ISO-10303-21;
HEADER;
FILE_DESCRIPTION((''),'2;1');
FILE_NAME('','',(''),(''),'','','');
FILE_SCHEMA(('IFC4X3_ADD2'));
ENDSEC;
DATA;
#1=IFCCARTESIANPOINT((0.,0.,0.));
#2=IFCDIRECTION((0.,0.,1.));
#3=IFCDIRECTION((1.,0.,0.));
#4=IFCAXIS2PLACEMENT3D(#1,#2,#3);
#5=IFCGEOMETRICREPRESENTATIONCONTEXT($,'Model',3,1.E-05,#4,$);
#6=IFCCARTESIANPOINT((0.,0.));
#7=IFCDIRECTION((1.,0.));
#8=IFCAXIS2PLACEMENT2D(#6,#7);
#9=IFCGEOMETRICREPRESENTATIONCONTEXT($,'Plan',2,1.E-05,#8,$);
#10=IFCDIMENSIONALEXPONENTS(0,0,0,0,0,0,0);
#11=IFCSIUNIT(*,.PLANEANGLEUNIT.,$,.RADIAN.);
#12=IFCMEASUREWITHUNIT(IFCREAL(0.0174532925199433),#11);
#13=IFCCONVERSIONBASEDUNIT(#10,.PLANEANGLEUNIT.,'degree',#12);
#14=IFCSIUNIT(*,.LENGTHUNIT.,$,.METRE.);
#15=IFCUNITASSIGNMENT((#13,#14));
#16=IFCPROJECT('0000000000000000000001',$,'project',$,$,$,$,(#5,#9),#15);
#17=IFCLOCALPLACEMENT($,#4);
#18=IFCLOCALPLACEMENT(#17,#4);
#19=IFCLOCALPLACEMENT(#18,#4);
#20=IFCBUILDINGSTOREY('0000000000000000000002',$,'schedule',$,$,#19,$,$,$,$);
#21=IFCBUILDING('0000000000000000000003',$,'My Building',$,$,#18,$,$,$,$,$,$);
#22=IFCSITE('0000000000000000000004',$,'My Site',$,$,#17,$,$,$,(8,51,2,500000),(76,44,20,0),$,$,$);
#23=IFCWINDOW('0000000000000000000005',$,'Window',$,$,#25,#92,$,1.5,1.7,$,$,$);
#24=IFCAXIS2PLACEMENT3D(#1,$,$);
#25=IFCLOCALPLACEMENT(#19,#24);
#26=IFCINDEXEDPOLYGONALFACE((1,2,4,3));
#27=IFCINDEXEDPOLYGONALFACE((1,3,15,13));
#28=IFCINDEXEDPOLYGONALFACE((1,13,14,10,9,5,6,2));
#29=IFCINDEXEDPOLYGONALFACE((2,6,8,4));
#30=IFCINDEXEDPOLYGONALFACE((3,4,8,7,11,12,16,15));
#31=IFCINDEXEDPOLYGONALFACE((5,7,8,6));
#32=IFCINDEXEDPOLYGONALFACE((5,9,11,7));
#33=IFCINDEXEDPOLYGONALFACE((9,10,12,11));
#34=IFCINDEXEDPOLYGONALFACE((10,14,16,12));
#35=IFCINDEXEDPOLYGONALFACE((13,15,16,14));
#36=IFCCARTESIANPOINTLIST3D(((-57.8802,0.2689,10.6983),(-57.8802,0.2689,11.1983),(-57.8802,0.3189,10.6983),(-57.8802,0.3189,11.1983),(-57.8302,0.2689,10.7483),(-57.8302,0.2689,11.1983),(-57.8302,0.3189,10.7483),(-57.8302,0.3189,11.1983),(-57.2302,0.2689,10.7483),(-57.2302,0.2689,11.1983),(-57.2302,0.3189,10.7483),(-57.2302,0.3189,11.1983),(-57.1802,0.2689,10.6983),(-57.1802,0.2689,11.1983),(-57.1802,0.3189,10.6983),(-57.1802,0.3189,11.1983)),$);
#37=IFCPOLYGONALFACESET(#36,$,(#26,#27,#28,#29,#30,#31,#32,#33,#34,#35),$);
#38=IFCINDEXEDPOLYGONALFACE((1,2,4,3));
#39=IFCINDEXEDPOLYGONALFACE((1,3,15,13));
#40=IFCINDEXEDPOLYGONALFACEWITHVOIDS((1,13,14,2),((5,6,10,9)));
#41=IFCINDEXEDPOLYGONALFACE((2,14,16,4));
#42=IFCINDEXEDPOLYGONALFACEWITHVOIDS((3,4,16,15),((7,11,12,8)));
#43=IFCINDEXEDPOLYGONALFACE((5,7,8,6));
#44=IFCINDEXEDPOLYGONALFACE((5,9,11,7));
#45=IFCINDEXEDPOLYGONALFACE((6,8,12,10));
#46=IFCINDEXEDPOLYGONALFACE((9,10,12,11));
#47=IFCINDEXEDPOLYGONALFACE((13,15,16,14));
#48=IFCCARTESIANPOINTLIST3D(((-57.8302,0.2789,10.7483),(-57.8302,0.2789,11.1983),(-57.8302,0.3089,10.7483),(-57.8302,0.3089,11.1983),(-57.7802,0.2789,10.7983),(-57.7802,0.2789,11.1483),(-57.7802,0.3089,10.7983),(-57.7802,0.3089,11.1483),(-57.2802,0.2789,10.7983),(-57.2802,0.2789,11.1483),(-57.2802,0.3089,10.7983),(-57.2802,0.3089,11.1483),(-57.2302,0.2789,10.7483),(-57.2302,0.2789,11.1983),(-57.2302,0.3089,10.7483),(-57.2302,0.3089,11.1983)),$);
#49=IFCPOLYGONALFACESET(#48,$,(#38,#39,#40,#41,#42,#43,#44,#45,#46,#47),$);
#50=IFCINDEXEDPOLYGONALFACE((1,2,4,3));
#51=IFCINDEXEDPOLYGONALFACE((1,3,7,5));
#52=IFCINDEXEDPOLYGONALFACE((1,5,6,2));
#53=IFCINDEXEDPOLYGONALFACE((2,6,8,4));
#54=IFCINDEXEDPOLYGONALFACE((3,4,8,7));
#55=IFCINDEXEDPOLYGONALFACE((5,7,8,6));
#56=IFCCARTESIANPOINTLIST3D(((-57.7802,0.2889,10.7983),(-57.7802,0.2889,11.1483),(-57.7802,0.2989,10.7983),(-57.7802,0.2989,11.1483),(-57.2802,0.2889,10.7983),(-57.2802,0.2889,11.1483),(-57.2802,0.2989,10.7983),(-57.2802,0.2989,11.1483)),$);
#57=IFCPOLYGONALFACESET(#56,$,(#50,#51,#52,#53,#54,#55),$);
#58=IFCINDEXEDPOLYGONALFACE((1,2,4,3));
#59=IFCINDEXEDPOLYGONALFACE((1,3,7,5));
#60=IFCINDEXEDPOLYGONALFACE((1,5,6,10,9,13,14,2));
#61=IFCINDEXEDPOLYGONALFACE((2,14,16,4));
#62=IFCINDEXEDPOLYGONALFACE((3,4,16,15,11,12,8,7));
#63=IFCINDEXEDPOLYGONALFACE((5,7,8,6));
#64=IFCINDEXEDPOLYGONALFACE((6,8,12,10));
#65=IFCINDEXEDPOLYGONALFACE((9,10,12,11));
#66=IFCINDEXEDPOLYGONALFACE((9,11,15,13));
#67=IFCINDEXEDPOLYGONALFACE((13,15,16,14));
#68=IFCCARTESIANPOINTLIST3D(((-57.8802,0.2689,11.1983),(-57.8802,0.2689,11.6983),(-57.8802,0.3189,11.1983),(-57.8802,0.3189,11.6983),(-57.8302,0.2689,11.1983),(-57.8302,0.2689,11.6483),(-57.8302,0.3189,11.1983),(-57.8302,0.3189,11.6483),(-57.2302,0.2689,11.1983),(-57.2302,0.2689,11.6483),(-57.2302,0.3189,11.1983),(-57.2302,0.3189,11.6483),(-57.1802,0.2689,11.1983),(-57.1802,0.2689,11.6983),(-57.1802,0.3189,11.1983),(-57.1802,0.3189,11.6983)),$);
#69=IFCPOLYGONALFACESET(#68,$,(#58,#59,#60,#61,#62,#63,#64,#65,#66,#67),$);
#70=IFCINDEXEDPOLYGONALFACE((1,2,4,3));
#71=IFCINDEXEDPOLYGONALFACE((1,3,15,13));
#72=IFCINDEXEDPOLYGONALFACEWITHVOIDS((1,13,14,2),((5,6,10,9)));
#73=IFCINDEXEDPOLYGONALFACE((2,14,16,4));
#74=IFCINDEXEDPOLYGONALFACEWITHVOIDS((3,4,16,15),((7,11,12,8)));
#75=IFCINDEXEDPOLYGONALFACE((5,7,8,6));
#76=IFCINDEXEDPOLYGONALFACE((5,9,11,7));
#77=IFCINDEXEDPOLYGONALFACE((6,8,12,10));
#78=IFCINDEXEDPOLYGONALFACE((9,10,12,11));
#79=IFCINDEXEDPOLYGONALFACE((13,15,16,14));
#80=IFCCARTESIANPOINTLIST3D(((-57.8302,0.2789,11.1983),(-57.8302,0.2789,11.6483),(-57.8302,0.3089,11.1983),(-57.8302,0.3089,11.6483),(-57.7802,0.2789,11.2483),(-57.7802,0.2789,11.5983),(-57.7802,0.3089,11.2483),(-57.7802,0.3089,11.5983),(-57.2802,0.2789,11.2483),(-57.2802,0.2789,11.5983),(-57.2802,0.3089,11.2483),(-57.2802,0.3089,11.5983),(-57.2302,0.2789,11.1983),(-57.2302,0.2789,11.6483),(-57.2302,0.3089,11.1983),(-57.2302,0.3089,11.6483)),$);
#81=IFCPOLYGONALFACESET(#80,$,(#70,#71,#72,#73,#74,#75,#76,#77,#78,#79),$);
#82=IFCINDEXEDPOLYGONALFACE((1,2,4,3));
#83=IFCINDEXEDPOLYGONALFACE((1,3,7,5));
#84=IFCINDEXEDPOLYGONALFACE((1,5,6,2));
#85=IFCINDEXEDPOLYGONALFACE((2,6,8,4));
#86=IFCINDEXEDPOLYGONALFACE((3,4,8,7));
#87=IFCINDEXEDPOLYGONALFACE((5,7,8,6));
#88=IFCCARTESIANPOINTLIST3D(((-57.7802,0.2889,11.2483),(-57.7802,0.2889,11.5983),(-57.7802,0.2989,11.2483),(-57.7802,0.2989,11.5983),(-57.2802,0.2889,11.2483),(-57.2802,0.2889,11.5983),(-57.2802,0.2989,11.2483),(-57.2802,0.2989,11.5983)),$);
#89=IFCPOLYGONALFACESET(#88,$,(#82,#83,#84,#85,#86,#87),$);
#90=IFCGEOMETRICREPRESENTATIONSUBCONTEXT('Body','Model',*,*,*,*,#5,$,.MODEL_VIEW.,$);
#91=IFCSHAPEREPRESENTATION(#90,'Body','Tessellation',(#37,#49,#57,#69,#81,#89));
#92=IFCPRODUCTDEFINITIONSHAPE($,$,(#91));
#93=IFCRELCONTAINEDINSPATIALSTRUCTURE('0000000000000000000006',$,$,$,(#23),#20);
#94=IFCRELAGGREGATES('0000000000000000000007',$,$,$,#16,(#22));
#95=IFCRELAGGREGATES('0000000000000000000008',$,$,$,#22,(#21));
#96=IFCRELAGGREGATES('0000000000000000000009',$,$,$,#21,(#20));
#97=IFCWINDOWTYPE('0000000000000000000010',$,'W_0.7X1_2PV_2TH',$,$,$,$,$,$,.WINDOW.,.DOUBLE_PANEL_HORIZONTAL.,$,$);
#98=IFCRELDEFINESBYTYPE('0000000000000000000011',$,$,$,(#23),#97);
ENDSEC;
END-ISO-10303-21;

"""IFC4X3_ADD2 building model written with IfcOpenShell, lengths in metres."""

from ifc_helpers import new_model, entity, si_unit, converted_unit, frame, origin_with_axes, origin_2d_with_axis, place, context, subcontext, project, spatial, line, indexed_curve, outline, extrude, shape, source, transform, mapped, type_object, type_shapes, element, save


model = new_model("IFC4X3_ADD2")

# Units and contexts
model_context = context("Model", 3, precision=1e-05, world=origin_with_axes())
plan_context = context("Plan", 2, precision=1e-05, world=origin_2d_with_axis())
body_context_1 = subcontext(model_context, "Body", "Model", "MODEL_VIEW")
body_context_2 = subcontext(plan_context, "Body", "Plan", "PLAN_VIEW")
ifc_project = project(units=[converted_unit("PLANEANGLEUNIT", "degree", entity("IfcReal", 0.0174532925199433), si_unit("PLANEANGLEUNIT", "RADIAN"), dimensions=[0, 0, 0, 0, 0, 0, 0]), si_unit("LENGTHUNIT", "METRE")], contexts=[model_context, plan_context])

# Site, building, storey
site_placement = place(None, origin_with_axes())
site = spatial("IfcSite", under=ifc_project, at=site_placement, Name="My Site", RefLatitude=(8, 51, 2, 500000), RefLongitude=(76, 44, 20, 0))
building_placement = place(site_placement, origin_with_axes())
building = spatial("IfcBuilding", under=site, at=building_placement, Name="My Building")
storey_placement = place(building_placement, origin_with_axes())
storey = spatial("IfcBuildingStorey", under=building, at=storey_placement, Name="schedule")

# Window
placement_1 = place(storey_placement, frame((-67.8485, 0.2689, 3.1152), z_axis=(0.0, 0.0, 1.0), x_axis=(1.0, 0.0, 0.0)))
window_type_1 = type_object("IfcWindowType", Name="W_0.7X1_2PV_2TH", PartitioningType="DOUBLE_PANEL_HORIZONTAL", PredefinedType="WINDOW")
shared_shape_1 = source(origin_with_axes(), body_context_1, "Body", "SweptSolid", [
    extrude(outline(indexed_curve([(0.7, 0.5), (0.7, 0.0), (0.0, 0.0), (0.0, 0.5), (0.05, 0.5), (0.05, 0.05), (0.65, 0.05), (0.65, 0.5)], segments=[line(1, 2, 3, 4, 5, 6, 7, 8, 1)])), frame((0.0, 0.0, 0.0), z_axis=(0.0, -1.0, 0.0), x_axis=(1.0, 0.0, 0.0)), (0.0, 0.0, -1.0), 0.05),
    extrude(outline(indexed_curve([(0.0, 0.0), (0.6, 0.0), (0.6, 0.45), (0.0, 0.45)], segments=[line(1, 2, 3, 4, 1)]), holes=[indexed_curve([(0.05, 0.05), (0.55, 0.05), (0.55, 0.4), (0.05, 0.4)], segments=[line(1, 2, 3, 4, 1)])]), frame((0.05, 0.01, 0.05), z_axis=(0.0, -1.0, 0.0), x_axis=(1.0, 0.0, 0.0)), (0.0, 0.0, -1.0), 0.03),
    extrude(outline(indexed_curve([(0.05, 0.05), (0.55, 0.05), (0.55, 0.4), (0.05, 0.4)], segments=[line(1, 2, 3, 4, 1)])), frame((0.05, 0.02, 0.05), z_axis=(0.0, -1.0, 0.0), x_axis=(1.0, 0.0, 0.0)), (0.0, 0.0, -1.0), 0.01),
    extrude(outline(indexed_curve([(0.0, 0.0), (0.0, 0.5), (0.7, 0.5), (0.7, 0.0), (0.65, 0.0), (0.65, 0.45), (0.05, 0.45), (0.05, 0.0)], segments=[line(1, 2, 3, 4, 5, 6, 7, 8, 1)])), frame((0.0, 0.0, 0.5), z_axis=(0.0, -1.0, 0.0), x_axis=(1.0, 0.0, 0.0)), (0.0, 0.0, -1.0), 0.05),
    extrude(outline(indexed_curve([(0.0, 0.0), (0.6, 0.0), (0.6, 0.45), (0.0, 0.45)], segments=[line(1, 2, 3, 4, 1)]), holes=[indexed_curve([(0.05, 0.05), (0.55, 0.05), (0.55, 0.4), (0.05, 0.4)], segments=[line(1, 2, 3, 4, 1)])]), frame((0.05, 0.01, 0.5), z_axis=(0.0, -1.0, 0.0), x_axis=(1.0, 0.0, 0.0)), (0.0, 0.0, -1.0), 0.03),
    extrude(outline(indexed_curve([(0.05, 0.05), (0.55, 0.05), (0.55, 0.4), (0.05, 0.4)], segments=[line(1, 2, 3, 4, 1)])), frame((0.05, 0.02, 0.5), z_axis=(0.0, -1.0, 0.0), x_axis=(1.0, 0.0, 0.0)), (0.0, 0.0, -1.0), 0.01),
])
shared_shape_2 = source(origin_with_axes(), body_context_2, "Body", "Curve2D", [
    entity("IfcIndexedPolyCurve", entity("IfcCartesianPointList2D", [[0.05, 0.0], [0.65, 0.0]])),
    entity("IfcIndexedPolyCurve", entity("IfcCartesianPointList2D", [[0.0, 0.05], [0.05, 0.05], [0.05, 0.0], [0.0, 0.0]]), [entity("IfcLineIndex", [1, 2, 3, 4, 1])]),
    entity("IfcIndexedPolyCurve", entity("IfcCartesianPointList2D", [[0.7, 0.05], [0.65, 0.05], [0.65, 0.0], [0.7, 0.0]]), [entity("IfcLineIndex", [1, 2, 3, 4, 1])]),
    entity("IfcIndexedPolyCurve", entity("IfcCartesianPointList2D", [[0.05, 0.01], [0.1, 0.01], [0.1, 0.04], [0.05, 0.04]]), [entity("IfcLineIndex", [1, 2, 3, 4, 1])]),
    entity("IfcIndexedPolyCurve", entity("IfcCartesianPointList2D", [[0.65, 0.01], [0.6, 0.01], [0.6, 0.04], [0.65, 0.04]]), [entity("IfcLineIndex", [1, 2, 3, 4, 1])]),
    entity("IfcIndexedPolyCurve", entity("IfcCartesianPointList2D", [[0.1, 0.01], [0.6, 0.01]])),
    entity("IfcIndexedPolyCurve", entity("IfcCartesianPointList2D", [[0.1, 0.04], [0.6, 0.04]])),
    entity("IfcIndexedPolyCurve", entity("IfcCartesianPointList2D", [[0.1, 0.025], [0.6, 0.025]])),
])
type_shapes(window_type_1, [shared_shape_1, shared_shape_2])
placement_2 = place(placement_1, frame((9.9684, 0.0, 7.5831), z_axis=(0.0, 0.0, 1.0), x_axis=(1.0, 0.0, 0.0)))
window_1_placement = place(placement_2, origin_with_axes())
element("IfcWindow", 1, at=window_1_placement, inside=storey, type_object=window_type_1, Name="Window", OverallHeight=1.5, OverallWidth=1.7, shapes=[
    shape(body_context_1, "Body", "MappedRepresentation", [mapped(shared_shape_1, transform((0.0, 0.0, 0.0), x_axis=(1.0, 0.0, 0.0), y_axis=(0.0, 1.0, 0.0), z_axis=(0.0, 0.0, 1.0), scale=1.0))]),
    shape(body_context_2, "Body", "MappedRepresentation", [mapped(shared_shape_2, transform((0.0, 0.0, 0.0), x_axis=(1.0, 0.0, 0.0), y_axis=(0.0, 1.0, 0.0), z_axis=(0.0, 0.0, 1.0), scale=1.0))]),
])

save(model, "model.ifc")
